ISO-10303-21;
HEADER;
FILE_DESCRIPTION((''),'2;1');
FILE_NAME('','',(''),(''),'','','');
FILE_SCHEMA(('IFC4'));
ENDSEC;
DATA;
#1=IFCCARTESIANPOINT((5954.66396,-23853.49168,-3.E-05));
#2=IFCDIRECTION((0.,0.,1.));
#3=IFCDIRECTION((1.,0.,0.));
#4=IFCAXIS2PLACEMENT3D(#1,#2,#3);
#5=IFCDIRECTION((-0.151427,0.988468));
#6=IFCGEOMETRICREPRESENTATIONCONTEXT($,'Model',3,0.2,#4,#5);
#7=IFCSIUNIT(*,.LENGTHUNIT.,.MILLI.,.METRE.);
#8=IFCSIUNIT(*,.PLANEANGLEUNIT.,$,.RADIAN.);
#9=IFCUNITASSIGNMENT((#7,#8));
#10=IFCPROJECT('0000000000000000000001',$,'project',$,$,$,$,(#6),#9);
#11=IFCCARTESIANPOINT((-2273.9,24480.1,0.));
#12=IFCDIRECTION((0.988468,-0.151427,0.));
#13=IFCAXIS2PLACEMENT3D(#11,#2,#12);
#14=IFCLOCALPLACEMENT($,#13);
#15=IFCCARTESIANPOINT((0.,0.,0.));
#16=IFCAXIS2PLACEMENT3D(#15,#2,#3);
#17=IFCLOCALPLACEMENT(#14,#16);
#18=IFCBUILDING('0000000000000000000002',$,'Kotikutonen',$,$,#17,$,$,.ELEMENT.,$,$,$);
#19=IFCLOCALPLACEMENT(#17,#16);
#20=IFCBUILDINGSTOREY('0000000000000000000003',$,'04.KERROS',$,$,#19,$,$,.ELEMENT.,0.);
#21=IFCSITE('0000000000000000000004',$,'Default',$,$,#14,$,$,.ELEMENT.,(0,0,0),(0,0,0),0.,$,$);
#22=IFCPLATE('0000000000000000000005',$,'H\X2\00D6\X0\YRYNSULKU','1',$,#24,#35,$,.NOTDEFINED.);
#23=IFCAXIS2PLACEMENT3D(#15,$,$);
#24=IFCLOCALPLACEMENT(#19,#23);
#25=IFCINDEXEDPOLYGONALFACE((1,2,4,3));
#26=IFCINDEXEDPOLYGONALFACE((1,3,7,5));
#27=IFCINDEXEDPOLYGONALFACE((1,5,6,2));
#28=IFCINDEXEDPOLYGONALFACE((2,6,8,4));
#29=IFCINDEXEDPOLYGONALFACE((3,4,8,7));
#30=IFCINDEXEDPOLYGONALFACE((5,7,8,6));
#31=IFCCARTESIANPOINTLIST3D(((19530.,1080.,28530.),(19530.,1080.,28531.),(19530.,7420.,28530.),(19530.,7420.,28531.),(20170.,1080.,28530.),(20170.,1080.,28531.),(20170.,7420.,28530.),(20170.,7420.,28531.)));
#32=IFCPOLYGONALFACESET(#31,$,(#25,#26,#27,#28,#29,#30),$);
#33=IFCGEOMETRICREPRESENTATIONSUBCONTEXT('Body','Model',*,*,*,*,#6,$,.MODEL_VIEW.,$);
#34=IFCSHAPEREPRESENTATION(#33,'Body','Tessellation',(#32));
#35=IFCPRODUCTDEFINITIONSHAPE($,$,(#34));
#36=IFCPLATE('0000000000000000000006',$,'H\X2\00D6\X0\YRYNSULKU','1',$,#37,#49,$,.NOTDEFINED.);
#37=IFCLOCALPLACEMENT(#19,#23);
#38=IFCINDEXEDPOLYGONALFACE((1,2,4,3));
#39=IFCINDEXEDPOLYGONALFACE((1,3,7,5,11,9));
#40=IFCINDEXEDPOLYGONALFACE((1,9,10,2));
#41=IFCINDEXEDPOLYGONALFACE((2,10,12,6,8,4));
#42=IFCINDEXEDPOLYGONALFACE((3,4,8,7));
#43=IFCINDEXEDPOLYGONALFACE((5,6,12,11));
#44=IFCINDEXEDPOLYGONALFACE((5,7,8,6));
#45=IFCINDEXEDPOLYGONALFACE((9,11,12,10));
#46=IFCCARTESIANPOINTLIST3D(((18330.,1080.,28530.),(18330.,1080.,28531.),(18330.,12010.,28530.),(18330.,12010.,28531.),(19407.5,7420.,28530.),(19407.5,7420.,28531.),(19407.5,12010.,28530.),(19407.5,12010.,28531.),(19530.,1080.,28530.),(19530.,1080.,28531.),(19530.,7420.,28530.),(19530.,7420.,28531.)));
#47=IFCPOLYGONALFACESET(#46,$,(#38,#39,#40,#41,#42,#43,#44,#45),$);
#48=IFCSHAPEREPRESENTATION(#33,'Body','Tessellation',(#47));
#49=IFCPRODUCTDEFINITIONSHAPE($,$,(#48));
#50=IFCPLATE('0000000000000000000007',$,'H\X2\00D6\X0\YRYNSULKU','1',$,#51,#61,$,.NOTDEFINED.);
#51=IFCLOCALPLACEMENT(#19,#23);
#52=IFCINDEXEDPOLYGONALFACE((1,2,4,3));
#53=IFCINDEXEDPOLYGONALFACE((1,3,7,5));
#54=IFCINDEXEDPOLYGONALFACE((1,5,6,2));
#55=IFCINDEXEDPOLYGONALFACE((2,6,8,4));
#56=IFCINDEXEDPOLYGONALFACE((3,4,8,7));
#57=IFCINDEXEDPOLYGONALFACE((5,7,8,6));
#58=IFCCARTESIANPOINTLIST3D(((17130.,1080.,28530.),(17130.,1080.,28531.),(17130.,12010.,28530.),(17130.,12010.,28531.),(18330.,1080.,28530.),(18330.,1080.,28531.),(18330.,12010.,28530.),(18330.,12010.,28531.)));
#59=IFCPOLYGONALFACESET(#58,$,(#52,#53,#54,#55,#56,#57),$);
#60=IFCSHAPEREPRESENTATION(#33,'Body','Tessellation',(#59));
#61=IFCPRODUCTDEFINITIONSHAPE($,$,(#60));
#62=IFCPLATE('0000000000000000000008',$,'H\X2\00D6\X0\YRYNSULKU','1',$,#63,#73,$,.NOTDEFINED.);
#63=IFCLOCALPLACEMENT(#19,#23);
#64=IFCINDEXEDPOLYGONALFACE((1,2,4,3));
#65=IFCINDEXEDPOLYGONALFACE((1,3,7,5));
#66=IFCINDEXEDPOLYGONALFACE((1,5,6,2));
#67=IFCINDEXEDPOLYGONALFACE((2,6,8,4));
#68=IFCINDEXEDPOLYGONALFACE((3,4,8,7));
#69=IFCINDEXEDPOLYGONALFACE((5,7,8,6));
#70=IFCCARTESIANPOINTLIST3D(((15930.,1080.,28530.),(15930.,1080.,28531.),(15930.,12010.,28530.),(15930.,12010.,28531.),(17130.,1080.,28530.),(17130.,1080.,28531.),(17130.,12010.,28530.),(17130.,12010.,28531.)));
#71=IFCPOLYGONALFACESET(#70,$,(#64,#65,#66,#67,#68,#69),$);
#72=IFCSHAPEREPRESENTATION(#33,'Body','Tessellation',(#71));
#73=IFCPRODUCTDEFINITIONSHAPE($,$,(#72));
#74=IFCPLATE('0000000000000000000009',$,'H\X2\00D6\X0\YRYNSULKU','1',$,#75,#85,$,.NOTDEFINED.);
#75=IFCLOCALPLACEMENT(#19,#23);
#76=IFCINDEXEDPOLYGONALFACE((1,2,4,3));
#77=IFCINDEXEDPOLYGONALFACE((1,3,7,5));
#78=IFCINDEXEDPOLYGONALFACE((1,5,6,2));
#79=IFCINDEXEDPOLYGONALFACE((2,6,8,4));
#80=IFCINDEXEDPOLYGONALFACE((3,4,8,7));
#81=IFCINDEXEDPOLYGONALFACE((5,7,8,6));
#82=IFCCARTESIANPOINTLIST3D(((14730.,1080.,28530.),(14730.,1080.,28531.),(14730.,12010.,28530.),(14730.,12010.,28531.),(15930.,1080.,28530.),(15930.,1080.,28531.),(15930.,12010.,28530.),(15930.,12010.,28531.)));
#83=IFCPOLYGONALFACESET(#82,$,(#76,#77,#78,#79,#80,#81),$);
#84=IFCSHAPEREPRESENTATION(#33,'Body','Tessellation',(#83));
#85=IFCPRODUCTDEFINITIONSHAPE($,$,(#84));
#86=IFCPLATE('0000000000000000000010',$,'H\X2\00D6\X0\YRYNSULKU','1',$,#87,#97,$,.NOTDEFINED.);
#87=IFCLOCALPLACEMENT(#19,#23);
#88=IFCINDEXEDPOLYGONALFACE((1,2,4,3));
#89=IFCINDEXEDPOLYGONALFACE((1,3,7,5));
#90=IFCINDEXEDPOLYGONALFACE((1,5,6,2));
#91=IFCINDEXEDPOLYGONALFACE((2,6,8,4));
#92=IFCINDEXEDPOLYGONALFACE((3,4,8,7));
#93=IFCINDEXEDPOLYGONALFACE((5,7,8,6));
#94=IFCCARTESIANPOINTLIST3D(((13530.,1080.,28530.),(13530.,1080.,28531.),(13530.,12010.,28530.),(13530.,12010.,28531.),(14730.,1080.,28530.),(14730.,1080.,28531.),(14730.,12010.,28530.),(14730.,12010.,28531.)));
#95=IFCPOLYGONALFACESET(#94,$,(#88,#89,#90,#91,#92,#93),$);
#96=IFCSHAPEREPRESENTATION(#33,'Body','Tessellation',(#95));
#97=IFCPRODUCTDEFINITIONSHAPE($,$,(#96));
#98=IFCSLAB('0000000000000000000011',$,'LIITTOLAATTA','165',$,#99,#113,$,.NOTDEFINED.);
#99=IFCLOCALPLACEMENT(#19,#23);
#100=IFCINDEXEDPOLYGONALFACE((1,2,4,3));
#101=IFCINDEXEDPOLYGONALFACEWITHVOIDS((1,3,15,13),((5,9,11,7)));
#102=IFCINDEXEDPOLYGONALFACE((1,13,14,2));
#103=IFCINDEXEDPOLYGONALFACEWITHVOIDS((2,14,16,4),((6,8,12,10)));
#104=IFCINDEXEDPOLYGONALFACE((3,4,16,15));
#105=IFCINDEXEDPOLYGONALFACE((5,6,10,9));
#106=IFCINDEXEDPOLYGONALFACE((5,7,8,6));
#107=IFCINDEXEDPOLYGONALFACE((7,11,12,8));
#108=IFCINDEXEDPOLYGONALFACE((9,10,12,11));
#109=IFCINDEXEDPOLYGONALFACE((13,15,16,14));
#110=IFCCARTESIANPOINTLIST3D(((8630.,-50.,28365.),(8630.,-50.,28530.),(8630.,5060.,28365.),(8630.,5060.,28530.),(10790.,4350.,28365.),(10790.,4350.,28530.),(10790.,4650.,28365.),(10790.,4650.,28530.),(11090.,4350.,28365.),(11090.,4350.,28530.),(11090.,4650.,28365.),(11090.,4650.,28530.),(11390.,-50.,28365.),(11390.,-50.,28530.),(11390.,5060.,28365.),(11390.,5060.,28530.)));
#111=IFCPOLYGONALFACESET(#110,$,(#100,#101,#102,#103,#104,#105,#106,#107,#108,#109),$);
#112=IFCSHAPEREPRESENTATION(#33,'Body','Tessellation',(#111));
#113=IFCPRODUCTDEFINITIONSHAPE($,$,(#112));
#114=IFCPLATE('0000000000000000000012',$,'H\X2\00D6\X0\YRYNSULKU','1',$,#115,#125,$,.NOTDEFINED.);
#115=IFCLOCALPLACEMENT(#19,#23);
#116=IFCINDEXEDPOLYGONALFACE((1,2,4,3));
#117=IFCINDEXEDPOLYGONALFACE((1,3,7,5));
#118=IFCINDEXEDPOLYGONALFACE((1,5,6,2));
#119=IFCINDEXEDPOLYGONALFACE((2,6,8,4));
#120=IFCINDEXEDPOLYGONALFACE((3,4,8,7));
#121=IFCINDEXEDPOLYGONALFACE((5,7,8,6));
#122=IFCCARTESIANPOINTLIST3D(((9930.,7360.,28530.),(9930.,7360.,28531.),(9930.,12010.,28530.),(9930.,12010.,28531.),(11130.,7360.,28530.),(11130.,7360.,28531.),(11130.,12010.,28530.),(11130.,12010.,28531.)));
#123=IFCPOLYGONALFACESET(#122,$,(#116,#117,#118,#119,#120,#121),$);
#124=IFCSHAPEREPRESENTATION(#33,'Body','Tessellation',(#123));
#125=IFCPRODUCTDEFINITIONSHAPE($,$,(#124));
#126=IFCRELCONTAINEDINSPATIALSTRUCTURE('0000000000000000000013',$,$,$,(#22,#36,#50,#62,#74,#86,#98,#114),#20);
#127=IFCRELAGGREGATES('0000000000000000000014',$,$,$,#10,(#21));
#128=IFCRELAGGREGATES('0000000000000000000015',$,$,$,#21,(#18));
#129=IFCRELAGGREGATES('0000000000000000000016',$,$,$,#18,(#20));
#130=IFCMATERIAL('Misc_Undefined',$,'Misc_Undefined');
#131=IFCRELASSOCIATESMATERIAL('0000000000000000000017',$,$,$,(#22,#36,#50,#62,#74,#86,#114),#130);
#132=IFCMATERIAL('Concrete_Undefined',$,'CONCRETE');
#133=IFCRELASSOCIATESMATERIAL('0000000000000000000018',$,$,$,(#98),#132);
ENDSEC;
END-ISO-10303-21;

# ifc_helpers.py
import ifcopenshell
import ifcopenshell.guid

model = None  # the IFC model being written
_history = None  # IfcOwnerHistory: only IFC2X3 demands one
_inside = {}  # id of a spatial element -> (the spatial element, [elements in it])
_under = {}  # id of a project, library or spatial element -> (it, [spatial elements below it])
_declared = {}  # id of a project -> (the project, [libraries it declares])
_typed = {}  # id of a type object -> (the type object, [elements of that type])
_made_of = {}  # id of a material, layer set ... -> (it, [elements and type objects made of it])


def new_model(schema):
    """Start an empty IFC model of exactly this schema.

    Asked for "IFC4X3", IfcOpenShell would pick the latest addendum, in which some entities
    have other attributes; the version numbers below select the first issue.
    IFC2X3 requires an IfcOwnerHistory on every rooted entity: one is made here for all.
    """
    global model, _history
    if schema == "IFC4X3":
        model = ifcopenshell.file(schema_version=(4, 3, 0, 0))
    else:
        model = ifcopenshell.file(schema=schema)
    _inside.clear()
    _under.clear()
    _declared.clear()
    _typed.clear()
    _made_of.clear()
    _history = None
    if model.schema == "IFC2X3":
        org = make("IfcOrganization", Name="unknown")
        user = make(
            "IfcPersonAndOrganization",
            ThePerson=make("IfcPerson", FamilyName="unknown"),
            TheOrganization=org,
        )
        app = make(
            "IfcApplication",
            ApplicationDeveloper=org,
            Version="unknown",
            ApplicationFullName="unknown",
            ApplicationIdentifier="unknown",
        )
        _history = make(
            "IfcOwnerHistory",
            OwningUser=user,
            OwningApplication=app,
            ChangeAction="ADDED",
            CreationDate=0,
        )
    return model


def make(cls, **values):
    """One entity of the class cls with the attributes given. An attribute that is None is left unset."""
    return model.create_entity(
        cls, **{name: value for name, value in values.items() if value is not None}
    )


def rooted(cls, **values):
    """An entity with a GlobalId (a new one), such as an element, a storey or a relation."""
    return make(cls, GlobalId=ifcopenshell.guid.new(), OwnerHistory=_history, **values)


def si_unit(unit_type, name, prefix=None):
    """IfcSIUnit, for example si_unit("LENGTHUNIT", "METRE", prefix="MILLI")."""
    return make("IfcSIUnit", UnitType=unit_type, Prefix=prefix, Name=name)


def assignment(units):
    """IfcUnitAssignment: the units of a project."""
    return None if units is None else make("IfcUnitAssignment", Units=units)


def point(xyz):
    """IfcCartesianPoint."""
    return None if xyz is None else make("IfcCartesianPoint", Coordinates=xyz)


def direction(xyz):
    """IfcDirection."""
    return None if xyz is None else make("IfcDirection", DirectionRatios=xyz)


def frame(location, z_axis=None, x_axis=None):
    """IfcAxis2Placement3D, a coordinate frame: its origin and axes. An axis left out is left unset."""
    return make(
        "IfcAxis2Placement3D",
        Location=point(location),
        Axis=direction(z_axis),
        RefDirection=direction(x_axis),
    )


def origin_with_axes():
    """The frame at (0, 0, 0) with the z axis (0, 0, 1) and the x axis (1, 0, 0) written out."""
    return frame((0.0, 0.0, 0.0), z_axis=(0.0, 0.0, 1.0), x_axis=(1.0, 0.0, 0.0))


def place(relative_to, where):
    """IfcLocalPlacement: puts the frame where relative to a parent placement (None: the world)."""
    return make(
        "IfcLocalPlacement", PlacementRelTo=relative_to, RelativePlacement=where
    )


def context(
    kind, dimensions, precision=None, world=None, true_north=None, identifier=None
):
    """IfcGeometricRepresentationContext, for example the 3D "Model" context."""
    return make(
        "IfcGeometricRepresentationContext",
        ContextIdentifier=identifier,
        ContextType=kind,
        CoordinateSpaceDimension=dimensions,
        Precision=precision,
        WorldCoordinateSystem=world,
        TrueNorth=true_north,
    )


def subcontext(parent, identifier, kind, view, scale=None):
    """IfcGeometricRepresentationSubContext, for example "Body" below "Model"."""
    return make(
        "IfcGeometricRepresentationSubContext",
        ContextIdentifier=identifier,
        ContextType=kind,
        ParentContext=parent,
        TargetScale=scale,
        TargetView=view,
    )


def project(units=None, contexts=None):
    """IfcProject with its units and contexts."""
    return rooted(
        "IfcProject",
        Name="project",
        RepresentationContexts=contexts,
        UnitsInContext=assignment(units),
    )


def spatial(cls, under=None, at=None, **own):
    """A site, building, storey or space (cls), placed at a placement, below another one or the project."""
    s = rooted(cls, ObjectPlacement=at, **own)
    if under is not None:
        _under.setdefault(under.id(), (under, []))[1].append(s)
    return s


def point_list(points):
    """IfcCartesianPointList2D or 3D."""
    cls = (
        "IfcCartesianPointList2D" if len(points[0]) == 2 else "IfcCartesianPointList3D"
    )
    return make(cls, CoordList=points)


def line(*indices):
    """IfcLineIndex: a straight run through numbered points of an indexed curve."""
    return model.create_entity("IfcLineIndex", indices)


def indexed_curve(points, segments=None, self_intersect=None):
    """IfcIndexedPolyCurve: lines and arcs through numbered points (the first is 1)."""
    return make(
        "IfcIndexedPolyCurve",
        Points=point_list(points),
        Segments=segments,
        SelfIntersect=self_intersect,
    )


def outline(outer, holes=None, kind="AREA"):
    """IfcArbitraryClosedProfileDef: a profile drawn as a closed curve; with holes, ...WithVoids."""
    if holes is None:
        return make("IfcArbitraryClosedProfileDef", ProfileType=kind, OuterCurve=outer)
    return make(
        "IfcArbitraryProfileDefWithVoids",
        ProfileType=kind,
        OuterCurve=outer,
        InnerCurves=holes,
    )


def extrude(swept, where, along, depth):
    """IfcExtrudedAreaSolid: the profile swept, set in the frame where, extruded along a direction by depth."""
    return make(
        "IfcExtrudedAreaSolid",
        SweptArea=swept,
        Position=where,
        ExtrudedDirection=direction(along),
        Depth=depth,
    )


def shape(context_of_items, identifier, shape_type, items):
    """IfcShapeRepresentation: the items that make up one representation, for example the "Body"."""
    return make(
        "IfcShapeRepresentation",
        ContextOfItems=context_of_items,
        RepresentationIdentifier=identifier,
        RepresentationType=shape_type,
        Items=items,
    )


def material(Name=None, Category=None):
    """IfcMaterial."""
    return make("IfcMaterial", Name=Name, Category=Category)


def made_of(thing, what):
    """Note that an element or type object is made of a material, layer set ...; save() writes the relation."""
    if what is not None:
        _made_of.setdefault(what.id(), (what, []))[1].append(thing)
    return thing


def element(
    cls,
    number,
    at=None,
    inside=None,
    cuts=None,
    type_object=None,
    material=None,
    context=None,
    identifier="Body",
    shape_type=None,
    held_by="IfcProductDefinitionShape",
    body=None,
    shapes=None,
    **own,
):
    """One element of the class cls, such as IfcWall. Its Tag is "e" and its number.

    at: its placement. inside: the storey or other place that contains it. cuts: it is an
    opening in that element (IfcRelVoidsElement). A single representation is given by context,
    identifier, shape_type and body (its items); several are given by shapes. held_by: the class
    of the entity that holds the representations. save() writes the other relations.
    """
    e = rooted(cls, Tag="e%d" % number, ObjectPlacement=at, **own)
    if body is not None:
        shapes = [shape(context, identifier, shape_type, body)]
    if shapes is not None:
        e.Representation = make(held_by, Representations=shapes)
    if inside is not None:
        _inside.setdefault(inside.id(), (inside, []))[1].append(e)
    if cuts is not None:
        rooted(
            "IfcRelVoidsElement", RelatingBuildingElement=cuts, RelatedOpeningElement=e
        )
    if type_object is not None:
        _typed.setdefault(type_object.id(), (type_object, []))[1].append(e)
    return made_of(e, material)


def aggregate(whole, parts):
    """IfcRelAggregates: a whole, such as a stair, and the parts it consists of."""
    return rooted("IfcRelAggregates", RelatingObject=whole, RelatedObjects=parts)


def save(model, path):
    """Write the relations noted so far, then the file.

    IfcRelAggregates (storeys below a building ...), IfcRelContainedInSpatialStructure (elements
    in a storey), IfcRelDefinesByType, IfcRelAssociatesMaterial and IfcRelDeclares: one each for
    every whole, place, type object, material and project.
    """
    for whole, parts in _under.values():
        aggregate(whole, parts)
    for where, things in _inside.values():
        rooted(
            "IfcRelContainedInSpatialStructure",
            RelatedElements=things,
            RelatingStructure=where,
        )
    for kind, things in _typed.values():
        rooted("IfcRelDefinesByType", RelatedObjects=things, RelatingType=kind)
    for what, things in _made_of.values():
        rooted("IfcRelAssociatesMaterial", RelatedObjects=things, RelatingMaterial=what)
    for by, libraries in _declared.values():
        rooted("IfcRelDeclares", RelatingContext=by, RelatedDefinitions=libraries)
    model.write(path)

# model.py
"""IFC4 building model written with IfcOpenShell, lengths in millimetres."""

from ifc_helpers import new_model, si_unit, direction, frame, origin_with_axes, place, context, subcontext, project, spatial, line, indexed_curve, outline, extrude, material, element, save


model = new_model("IFC4")

# Units and contexts
model_context = context("Model", 3, precision=0.2, world=frame((5954.66396, -23853.49168, -3e-05), z_axis=(0.0, 0.0, 1.0), x_axis=(1.0, 0.0, 0.0)), true_north=direction((-0.151427, 0.988468)))
body_context = subcontext(model_context, "Body", "Model", "MODEL_VIEW")
ifc_project = project(units=[si_unit("LENGTHUNIT", "METRE", prefix="MILLI"), si_unit("PLANEANGLEUNIT", "RADIAN")], contexts=[model_context])

# Site, building, storey
site_placement = place(None, frame((-2273.9, 24480.1, 0.0), z_axis=(0.0, 0.0, 1.0), x_axis=(0.988468, -0.151427, 0.0)))
site = spatial("IfcSite", under=ifc_project, at=site_placement, Name="Default", CompositionType="ELEMENT", RefLatitude=(0, 0, 0), RefLongitude=(0, 0, 0), RefElevation=0.0)
building_placement = place(site_placement, origin_with_axes())
building = spatial("IfcBuilding", under=site, at=building_placement, Name="Kotikutonen", CompositionType="ELEMENT")
storey_placement = place(building_placement, origin_with_axes())
storey = spatial("IfcBuildingStorey", under=building, at=storey_placement, Name="04.KERROS", CompositionType="ELEMENT", Elevation=0.0)

# Shared definitions
ifc_material_1 = material(Name="Concrete_Undefined", Category="CONCRETE")

# Plates
ifc_material_2 = material(Name="Misc_Undefined", Category="Misc_Undefined")
plate_1_placement = place(storey_placement, frame((19530.0, 1080.0, 28530.5), z_axis=(0.0, 0.0, 1.0), x_axis=(1.0, 0.0, 0.0)))
element("IfcPlate", 1, at=plate_1_placement, inside=storey, material=ifc_material_2, Name="HÖYRYNSULKU", Description="1", PredefinedType="NOTDEFINED", context=body_context, shape_type="SolidModel", body=[
    extrude(outline(indexed_curve([(0.0, 0.0), (640.0, 0.0), (640.0, 6340.0), (0.0, 6340.0)], segments=[line(1, 2, 3, 4, 1)])), frame((0.0, 0.0, 0.5), z_axis=(0.0, 0.0, 1.0), x_axis=(1.0, 0.0, 0.0)), (0.0, 0.0, -1.0), 1.0),
])
plate_2_placement = place(storey_placement, frame((18330.0, 1080.0, 28530.5), z_axis=(0.0, 0.0, 1.0), x_axis=(1.0, 0.0, 0.0)))
element("IfcPlate", 2, at=plate_2_placement, inside=storey, material=ifc_material_2, Name="HÖYRYNSULKU", Description="1", PredefinedType="NOTDEFINED", context=body_context, shape_type="SolidModel", body=[
    extrude(outline(indexed_curve([(0.0, 0.0), (1200.0, 0.0), (1200.0, 6340.0), (1077.5, 6340.0), (1077.5, 10930.0), (0.0, 10930.0)], segments=[line(1, 2, 3, 4, 5, 6, 1)])), frame((0.0, 0.0, 0.5), z_axis=(0.0, 0.0, 1.0), x_axis=(1.0, 0.0, 0.0)), (0.0, 0.0, -1.0), 1.0),
])
for number, where, z_axis, x_axis, name in (
    (3, (17130.0, 1080.0, 28530.5), (0.0, 0.0, 1.0), (1.0, 0.0, 0.0), "HÖYRYNSULKU"),
    (4, (15930.0, 1080.0, 28530.5), (0.0, 0.0, 1.0), (1.0, 0.0, 0.0), "HÖYRYNSULKU"),
    (5, (14730.0, 1080.0, 28530.5), (0.0, 0.0, 1.0), (1.0, 0.0, 0.0), "HÖYRYNSULKU"),
    (6, (13530.0, 1080.0, 28530.5), (0.0, 0.0, 1.0), (1.0, 0.0, 0.0), "HÖYRYNSULKU"),
):
    element("IfcPlate", number, at=place(storey_placement, frame(where, z_axis=z_axis, x_axis=x_axis)), inside=storey, material=ifc_material_2, Name=name, Description="1", PredefinedType="NOTDEFINED", context=body_context, shape_type="SolidModel", body=[
        extrude(outline(indexed_curve([(0.0, 0.0), (1200.0, 0.0), (1200.0, 10930.0), (0.0, 10930.0)], segments=[line(1, 2, 3, 4, 1)])), frame((0.0, 0.0, 0.5), z_axis=(0.0, 0.0, 1.0), x_axis=(1.0, 0.0, 0.0)), (0.0, 0.0, -1.0), 1.0),
    ])

# Slab, voiding feature
slab_1_placement = place(storey_placement, frame((11390.0, 5060.0, 28447.5), z_axis=(0.0, 0.0, 1.0), x_axis=(-1.0, 0.0, 0.0)))
slab_1 = element("IfcSlab", 7, at=slab_1_placement, inside=storey, material=ifc_material_1, Name="LIITTOLAATTA", Description="165", PredefinedType="NOTDEFINED", context=body_context, shape_type="SolidModel", body=[
    extrude(outline(indexed_curve([(0.0, 0.0), (2760.0, 0.0), (2760.0, 5110.0), (0.0, 5110.0)], segments=[line(1, 2, 3, 4, 1)])), frame((0.0, 0.0, 82.5), z_axis=(0.0, 0.0, 1.0), x_axis=(1.0, 0.0, 0.0)), (0.0, 0.0, -1.0), 165.0),
])
voiding_feature_1_placement = place(slab_1_placement, frame((300.0, 410.0, 0.0), z_axis=(0.0, 0.0, 1.0), x_axis=(1.0, 0.0, 0.0)))
element("IfcVoidingFeature", 8, at=voiding_feature_1_placement, cuts=slab_1, Name="POLYGON CUT", PredefinedType="HOLE", context=body_context, shape_type="SolidModel", body=[
    extrude(outline(indexed_curve([(0.0, 0.0), (300.0, 0.0), (300.0, 300.0), (0.0, 300.0)], segments=[line(1, 2, 3, 4, 1)])), frame((0.0, 0.0, 157.5), z_axis=(0.0, 0.0, 1.0), x_axis=(1.0, 0.0, 0.0)), (0.0, 0.0, -1.0), 315.0),
])

# Plate
plate_3_placement = place(storey_placement, frame((9930.0, 7360.0, 28530.5), z_axis=(0.0, 0.0, 1.0), x_axis=(1.0, 0.0, 0.0)))
element("IfcPlate", 9, at=plate_3_placement, inside=storey, material=ifc_material_2, Name="HÖYRYNSULKU", Description="1", PredefinedType="NOTDEFINED", context=body_context, shape_type="SolidModel", body=[
    extrude(outline(indexed_curve([(0.0, 0.0), (1200.0, 0.0), (1200.0, 4650.0), (0.0, 4650.0)], segments=[line(1, 2, 3, 4, 1)])), frame((0.0, 0.0, 0.5), z_axis=(0.0, 0.0, 1.0), x_axis=(1.0, 0.0, 0.0)), (0.0, 0.0, -1.0), 1.0),
])

save(model, "model.ifc")
